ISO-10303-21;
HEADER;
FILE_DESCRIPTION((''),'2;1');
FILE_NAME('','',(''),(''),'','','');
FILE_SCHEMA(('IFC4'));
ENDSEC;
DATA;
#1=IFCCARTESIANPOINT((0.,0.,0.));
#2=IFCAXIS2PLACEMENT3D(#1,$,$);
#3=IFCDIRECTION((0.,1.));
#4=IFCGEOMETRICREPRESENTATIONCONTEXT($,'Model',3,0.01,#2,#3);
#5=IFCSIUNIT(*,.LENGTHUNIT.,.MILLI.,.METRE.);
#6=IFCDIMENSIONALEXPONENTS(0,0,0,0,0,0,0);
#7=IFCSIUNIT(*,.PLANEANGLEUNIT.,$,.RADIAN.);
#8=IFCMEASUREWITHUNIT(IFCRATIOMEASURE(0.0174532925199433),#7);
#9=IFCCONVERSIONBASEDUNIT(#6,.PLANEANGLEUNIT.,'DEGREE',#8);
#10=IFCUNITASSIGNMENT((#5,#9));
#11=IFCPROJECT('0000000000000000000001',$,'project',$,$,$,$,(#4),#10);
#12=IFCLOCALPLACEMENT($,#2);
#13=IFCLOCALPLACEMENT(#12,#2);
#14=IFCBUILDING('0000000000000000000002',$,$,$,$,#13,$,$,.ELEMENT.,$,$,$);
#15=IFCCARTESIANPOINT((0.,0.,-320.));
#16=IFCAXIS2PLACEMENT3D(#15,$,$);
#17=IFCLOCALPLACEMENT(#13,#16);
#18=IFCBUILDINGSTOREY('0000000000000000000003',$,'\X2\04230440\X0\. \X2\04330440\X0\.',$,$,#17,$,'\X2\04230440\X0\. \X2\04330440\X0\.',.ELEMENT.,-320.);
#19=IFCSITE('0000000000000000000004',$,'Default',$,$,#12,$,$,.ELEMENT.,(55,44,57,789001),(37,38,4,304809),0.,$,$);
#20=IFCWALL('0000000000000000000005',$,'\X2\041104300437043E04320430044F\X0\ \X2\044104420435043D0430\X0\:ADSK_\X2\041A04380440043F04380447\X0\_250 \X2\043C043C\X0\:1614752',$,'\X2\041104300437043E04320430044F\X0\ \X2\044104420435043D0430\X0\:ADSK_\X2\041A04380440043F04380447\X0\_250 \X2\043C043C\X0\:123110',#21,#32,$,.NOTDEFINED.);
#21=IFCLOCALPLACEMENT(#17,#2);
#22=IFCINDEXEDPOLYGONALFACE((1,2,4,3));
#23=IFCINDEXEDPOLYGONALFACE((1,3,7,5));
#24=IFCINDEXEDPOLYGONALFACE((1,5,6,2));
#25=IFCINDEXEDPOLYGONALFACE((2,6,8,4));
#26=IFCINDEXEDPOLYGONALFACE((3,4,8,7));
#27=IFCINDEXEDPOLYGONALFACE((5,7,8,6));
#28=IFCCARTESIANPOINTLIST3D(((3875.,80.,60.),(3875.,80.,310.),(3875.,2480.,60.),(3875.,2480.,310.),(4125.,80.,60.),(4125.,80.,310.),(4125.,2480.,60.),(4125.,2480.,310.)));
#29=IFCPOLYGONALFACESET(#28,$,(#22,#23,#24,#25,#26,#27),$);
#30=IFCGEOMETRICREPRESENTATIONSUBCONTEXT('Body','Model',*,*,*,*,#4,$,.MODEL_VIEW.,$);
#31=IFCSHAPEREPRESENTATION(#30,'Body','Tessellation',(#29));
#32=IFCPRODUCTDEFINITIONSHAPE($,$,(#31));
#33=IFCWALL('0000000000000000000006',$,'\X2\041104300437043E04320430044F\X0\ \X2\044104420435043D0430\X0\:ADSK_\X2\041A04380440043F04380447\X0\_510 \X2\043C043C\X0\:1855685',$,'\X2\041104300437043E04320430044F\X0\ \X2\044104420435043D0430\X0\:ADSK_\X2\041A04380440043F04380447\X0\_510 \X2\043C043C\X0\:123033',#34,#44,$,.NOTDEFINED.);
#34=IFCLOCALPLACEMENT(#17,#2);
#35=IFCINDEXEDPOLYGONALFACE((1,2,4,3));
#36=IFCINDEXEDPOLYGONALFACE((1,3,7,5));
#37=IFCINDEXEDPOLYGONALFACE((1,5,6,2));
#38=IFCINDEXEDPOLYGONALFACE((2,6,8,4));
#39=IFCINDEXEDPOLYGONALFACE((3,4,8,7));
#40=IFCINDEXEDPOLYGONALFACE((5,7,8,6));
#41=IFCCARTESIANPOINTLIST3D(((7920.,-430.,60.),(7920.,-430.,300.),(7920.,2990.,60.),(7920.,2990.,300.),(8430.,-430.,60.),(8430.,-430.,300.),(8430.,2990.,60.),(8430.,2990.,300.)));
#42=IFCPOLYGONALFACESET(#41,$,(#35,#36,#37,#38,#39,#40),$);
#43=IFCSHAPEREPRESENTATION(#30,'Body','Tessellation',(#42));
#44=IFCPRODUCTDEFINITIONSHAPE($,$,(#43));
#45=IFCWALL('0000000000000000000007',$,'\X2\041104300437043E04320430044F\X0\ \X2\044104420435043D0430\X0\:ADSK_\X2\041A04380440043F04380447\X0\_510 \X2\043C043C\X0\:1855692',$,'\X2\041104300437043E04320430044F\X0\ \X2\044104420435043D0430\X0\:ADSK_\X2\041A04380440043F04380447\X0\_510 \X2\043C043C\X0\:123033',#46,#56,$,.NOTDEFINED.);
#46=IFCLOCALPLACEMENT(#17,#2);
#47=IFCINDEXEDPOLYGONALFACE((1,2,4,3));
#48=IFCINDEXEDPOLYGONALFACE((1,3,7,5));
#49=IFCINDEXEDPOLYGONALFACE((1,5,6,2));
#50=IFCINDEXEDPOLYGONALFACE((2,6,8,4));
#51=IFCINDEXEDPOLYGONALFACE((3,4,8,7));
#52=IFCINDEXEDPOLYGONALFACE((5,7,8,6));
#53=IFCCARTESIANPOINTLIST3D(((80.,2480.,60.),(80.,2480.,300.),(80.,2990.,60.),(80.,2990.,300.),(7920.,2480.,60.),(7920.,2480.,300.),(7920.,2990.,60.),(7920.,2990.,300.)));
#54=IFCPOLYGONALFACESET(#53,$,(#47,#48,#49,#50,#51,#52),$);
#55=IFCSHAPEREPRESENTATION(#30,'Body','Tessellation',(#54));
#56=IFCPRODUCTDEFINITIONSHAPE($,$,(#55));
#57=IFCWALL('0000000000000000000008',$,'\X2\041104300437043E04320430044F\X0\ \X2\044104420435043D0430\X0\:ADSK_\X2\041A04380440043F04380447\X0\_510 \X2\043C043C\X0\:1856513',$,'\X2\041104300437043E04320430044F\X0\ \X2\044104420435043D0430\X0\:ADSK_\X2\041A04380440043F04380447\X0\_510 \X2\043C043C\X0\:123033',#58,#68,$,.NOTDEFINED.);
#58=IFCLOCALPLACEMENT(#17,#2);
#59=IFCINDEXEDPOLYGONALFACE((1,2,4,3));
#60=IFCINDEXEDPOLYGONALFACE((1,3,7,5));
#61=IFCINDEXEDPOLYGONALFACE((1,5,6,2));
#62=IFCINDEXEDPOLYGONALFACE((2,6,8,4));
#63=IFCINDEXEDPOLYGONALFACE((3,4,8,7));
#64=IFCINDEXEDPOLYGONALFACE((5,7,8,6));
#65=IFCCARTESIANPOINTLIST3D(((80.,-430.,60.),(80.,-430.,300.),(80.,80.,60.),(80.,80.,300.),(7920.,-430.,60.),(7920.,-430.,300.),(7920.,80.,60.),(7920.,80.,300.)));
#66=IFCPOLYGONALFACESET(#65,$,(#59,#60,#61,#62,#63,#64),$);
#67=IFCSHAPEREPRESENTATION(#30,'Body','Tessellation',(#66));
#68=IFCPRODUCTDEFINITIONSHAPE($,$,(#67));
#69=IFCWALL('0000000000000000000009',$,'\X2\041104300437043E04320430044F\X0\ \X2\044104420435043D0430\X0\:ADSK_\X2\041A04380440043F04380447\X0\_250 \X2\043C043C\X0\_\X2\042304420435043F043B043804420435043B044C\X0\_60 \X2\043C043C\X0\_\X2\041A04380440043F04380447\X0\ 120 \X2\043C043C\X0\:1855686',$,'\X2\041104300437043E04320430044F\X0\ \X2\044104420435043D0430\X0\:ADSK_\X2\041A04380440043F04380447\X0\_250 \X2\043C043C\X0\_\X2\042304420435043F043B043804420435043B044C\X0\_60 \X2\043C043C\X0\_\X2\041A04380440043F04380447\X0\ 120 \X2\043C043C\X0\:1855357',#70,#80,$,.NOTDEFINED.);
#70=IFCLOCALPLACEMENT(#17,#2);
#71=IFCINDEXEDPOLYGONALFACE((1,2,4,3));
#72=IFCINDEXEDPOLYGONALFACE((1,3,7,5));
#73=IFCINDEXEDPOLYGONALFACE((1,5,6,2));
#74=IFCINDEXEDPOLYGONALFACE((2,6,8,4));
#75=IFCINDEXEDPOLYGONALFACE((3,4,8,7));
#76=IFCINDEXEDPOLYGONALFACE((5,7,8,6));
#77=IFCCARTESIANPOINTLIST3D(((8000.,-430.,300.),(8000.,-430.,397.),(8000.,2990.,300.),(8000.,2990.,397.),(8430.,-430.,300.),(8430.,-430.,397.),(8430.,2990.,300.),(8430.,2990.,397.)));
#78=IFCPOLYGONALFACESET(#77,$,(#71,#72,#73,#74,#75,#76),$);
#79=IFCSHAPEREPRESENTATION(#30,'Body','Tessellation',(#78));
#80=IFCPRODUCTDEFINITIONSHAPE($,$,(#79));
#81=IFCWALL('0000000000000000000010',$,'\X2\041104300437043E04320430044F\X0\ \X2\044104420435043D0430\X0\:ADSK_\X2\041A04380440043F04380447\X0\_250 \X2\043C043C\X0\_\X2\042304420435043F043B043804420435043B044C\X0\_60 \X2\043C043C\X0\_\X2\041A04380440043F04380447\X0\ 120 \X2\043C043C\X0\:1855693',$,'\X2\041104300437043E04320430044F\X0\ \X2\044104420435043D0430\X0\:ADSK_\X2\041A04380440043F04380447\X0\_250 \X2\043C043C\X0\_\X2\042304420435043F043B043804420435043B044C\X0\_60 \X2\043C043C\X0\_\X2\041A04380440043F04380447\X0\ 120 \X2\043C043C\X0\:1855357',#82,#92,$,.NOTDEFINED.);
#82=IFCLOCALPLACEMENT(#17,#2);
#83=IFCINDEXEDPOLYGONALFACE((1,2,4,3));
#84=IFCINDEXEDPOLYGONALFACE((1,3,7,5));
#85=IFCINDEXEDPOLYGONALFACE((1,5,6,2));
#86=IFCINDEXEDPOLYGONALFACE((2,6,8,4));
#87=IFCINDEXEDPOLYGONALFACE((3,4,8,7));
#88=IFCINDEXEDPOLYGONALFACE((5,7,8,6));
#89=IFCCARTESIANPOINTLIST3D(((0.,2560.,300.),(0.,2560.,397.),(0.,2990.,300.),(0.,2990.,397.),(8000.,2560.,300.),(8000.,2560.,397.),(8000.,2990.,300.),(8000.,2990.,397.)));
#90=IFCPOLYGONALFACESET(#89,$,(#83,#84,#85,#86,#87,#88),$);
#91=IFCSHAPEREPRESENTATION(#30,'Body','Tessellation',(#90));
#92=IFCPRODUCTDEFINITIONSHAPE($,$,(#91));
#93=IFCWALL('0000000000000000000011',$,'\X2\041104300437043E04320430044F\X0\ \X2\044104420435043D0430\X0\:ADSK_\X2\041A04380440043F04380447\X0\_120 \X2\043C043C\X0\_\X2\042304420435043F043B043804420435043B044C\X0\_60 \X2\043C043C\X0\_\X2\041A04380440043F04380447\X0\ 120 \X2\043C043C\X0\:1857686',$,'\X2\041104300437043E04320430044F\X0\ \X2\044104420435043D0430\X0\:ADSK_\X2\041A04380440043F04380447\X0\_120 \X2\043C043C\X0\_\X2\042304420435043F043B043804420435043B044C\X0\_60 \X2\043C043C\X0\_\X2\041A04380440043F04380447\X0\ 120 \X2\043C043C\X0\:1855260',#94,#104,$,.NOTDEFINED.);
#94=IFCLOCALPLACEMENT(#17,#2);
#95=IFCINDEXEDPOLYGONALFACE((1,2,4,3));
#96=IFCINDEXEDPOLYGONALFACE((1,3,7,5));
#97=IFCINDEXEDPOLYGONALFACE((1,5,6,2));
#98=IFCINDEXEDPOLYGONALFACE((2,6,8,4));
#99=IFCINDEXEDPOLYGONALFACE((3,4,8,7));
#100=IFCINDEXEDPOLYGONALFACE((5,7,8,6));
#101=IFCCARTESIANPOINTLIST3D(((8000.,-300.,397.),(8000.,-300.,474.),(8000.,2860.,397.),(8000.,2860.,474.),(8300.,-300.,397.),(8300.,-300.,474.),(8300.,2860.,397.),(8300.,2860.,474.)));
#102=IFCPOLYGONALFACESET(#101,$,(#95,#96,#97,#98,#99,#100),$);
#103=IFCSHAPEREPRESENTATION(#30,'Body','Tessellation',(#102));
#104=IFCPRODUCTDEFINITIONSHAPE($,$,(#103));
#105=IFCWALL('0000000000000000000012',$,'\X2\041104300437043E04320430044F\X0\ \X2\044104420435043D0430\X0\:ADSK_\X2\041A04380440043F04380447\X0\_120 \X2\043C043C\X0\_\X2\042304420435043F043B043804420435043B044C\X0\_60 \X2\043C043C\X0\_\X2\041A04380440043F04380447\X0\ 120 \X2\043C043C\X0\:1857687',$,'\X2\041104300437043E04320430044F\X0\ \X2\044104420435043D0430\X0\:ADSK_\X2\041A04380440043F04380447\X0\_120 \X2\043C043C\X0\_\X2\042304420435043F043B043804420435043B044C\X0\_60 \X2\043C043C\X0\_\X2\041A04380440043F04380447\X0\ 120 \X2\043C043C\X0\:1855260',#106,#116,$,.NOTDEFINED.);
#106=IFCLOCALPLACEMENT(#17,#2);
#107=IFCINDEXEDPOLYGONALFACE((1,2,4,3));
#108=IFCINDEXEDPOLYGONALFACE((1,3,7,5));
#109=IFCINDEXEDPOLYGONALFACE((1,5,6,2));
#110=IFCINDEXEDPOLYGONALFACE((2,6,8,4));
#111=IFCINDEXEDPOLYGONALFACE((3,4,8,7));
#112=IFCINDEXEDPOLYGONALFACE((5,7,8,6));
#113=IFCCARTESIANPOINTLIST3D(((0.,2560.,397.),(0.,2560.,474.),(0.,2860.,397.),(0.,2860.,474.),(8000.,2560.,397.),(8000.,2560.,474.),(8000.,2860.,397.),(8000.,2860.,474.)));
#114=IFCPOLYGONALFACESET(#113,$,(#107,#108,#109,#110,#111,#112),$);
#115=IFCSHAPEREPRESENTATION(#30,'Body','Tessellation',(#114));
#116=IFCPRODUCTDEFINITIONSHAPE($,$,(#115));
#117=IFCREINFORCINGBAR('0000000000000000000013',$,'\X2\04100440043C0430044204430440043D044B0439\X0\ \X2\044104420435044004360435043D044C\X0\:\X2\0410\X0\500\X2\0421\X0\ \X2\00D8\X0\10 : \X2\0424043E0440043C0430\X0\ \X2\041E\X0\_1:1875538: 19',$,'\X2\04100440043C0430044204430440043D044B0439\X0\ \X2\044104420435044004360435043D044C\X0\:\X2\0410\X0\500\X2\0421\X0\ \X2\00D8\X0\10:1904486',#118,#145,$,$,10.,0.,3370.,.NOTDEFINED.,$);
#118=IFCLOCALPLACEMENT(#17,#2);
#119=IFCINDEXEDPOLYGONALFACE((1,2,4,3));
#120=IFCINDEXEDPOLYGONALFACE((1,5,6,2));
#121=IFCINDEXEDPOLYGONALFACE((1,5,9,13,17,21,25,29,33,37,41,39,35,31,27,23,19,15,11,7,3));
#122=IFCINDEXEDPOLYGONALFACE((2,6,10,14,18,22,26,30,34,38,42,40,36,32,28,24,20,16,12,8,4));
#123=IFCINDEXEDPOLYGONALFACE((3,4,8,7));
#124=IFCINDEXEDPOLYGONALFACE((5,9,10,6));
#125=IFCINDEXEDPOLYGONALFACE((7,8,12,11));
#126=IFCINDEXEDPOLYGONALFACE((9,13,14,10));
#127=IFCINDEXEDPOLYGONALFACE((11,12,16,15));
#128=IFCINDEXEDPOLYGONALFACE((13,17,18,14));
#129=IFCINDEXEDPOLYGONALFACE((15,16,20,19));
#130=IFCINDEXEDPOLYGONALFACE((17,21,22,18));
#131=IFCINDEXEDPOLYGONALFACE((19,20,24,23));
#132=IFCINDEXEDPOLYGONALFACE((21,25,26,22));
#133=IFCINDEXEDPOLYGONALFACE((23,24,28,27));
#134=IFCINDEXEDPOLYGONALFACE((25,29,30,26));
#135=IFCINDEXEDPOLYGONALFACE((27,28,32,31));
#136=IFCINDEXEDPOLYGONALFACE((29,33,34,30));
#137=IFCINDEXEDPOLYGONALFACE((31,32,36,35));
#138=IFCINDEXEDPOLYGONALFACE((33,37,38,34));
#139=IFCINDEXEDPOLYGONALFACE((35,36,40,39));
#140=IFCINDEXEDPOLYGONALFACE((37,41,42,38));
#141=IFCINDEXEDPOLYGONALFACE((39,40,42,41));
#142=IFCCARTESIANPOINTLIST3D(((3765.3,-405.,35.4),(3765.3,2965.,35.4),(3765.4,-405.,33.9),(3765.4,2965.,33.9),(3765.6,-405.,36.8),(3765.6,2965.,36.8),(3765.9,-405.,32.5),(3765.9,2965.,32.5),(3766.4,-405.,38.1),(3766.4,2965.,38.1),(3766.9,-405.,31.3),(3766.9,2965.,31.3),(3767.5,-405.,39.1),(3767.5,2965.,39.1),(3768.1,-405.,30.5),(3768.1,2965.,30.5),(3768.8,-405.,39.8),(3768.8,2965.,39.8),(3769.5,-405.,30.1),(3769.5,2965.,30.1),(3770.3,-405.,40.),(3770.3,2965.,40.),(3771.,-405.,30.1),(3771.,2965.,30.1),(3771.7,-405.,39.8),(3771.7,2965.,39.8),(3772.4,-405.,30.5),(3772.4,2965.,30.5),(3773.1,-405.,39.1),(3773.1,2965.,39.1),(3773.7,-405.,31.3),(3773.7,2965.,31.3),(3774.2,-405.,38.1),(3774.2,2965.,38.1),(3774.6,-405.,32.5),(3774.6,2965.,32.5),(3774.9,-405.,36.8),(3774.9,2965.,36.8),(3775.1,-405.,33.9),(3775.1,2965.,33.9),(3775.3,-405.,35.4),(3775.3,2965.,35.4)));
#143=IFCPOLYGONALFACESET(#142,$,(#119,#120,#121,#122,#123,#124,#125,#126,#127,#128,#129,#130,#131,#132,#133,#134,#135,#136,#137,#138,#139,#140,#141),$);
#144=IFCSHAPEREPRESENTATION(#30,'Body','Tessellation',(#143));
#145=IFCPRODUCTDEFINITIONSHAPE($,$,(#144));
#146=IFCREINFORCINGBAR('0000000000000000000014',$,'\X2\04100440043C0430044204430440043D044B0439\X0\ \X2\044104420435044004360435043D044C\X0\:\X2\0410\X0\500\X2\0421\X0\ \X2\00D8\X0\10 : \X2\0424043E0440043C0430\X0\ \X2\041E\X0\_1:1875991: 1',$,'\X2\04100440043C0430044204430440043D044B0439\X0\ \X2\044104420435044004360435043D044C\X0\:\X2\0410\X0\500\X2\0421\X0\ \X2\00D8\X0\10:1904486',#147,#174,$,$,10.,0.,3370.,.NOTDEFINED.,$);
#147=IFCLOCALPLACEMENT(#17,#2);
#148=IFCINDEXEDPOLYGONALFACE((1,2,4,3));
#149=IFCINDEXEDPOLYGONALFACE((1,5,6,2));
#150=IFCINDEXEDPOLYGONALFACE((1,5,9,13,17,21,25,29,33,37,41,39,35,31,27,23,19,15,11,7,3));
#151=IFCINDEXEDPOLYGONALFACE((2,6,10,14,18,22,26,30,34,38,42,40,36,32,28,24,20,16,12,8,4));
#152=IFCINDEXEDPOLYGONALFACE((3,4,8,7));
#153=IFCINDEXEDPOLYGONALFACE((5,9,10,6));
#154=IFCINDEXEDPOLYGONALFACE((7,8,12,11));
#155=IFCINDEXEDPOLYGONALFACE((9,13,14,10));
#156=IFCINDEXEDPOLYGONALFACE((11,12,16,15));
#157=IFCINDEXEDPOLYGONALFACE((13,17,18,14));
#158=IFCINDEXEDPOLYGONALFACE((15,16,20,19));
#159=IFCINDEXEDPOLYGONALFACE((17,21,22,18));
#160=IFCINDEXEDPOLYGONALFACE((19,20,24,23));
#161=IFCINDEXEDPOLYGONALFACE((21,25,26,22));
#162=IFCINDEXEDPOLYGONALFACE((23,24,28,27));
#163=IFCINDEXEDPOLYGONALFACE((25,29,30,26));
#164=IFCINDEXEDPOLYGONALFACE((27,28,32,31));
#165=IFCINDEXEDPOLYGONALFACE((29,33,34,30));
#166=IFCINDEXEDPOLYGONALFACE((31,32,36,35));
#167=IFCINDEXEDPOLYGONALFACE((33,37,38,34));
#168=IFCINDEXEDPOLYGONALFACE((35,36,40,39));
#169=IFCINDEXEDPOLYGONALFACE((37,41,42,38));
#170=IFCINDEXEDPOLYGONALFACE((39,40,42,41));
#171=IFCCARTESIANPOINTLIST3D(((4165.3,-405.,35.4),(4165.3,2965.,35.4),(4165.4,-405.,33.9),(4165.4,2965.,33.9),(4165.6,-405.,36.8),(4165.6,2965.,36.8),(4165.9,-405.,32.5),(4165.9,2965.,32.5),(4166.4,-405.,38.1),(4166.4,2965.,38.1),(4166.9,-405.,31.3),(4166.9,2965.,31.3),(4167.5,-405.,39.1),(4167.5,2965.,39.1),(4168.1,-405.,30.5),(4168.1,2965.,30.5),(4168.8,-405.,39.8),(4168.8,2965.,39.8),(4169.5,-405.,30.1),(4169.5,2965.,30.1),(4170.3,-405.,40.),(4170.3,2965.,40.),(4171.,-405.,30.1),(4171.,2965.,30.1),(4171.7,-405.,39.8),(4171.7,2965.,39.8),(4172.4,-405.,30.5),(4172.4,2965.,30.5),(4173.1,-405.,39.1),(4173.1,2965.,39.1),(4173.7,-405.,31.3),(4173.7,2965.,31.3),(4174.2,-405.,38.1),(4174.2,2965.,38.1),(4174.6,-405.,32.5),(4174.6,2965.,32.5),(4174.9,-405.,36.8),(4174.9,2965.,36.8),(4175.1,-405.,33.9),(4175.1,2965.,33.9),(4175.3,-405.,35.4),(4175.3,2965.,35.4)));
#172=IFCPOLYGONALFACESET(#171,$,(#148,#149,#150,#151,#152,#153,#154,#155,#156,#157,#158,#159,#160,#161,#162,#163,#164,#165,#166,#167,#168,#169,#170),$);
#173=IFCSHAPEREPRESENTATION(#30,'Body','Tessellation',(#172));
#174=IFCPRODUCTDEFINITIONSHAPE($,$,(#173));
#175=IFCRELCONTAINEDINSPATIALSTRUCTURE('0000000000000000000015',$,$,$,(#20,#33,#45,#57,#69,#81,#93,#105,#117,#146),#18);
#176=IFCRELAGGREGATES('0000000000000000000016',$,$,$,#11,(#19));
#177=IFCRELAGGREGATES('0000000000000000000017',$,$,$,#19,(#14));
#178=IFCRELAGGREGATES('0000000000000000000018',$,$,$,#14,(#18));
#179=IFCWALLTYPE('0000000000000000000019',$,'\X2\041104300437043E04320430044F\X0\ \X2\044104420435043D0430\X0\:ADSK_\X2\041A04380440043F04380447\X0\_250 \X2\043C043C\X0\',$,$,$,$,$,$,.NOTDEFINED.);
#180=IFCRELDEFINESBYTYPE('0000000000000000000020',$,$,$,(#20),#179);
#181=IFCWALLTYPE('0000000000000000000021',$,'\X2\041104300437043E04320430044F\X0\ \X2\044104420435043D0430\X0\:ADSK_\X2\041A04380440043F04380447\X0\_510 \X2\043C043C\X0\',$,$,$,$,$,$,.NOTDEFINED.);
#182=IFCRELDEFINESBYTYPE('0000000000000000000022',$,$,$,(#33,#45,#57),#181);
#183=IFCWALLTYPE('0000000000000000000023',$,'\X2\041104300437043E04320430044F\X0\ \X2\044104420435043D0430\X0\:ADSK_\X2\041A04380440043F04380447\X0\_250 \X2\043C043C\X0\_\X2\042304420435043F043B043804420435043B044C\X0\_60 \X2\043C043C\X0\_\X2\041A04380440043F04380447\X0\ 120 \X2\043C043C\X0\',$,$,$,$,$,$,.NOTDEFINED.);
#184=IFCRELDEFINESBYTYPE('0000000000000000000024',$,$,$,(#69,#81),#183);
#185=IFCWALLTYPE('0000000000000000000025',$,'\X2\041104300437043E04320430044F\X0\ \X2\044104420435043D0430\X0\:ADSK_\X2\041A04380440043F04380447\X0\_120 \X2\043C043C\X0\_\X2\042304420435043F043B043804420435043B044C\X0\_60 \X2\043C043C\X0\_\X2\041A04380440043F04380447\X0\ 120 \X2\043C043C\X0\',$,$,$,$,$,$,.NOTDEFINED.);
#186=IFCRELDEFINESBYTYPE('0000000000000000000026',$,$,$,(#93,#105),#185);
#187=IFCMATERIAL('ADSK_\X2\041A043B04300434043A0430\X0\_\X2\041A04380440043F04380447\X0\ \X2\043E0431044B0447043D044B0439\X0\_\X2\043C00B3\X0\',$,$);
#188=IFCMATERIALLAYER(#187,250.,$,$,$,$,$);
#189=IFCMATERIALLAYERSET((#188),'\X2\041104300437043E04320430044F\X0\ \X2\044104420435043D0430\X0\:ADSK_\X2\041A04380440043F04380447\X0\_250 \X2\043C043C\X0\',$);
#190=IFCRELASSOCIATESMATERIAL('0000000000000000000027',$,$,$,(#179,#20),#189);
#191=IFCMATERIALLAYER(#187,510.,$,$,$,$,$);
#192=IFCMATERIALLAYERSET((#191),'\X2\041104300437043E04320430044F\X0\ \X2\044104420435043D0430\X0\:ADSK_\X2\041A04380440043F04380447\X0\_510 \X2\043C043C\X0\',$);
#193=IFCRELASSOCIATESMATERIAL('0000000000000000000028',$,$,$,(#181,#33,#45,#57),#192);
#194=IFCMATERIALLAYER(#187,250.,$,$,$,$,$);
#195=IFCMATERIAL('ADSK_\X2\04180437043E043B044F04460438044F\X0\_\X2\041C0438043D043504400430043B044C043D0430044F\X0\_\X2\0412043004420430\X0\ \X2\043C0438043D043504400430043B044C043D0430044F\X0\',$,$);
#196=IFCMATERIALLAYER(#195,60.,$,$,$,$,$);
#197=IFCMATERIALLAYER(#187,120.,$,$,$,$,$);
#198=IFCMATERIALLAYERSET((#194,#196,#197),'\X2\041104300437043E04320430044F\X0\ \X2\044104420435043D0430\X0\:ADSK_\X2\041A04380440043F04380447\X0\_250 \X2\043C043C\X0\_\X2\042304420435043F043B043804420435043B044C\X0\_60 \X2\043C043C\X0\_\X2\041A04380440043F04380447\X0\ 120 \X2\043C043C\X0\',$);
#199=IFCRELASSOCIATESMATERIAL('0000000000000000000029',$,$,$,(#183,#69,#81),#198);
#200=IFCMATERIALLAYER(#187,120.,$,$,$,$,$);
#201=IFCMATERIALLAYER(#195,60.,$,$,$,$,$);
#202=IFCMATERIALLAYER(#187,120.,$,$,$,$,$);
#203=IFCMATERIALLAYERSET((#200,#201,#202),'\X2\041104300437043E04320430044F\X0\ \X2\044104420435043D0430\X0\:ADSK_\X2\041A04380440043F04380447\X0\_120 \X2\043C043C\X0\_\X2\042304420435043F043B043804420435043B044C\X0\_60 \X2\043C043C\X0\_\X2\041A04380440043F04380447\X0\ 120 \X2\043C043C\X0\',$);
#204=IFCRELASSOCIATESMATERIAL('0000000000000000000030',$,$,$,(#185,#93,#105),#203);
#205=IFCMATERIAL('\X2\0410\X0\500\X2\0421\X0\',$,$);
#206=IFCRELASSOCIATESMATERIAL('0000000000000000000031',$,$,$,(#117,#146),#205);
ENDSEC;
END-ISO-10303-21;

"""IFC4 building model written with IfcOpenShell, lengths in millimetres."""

from ifc_helpers import new_model, entity, si_unit, converted_unit, direction, frame, frame_2d, origin, place, context, subcontext, project, spatial, polyline, rectangle, extrude, clip, bounded_halfspace, material, layer, layer_set, layer_usage, type_object, element, save


model = new_model("IFC4")

# Units and contexts
model_context = context("Model", 3, precision=0.01, world=origin(), true_north=direction((0.0, 1.0)))
body_context = subcontext(model_context, "Body", "Model", "MODEL_VIEW")
ifc_project = project(units=[si_unit("LENGTHUNIT", "METRE", prefix="MILLI"), converted_unit("PLANEANGLEUNIT", "DEGREE", entity("IfcRatioMeasure", 0.0174532925199433), si_unit("PLANEANGLEUNIT", "RADIAN"), dimensions=[0, 0, 0, 0, 0, 0, 0])], contexts=[model_context])

# Site, building, storey
site_placement = place(None, origin())
site = spatial("IfcSite", under=ifc_project, at=site_placement, Name="Default", CompositionType="ELEMENT", RefLatitude=(55, 44, 57, 789001), RefLongitude=(37, 38, 4, 304809), RefElevation=0.0)
building_placement = place(site_placement, origin())
building = spatial("IfcBuilding", under=site, at=building_placement, CompositionType="ELEMENT")
storey_placement = place(building_placement, frame((0.0, 0.0, -320.0)))
storey = spatial("IfcBuildingStorey", under=building, at=storey_placement, Name="Ур. гр.", LongName="Ур. гр.", CompositionType="ELEMENT", Elevation=-320.0)

# Walls
ifc_material_1 = material(Name="ADSK_Кладка_Кирпич обычный_м³")
ifc_layer_1 = layer(ifc_material_1, 250.0)
ifc_layer_set_1 = layer_set([ifc_layer_1], Name="Базовая стена:ADSK_Кирпич_250 мм")
ifc_layer_usage_1 = layer_usage(ifc_layer_set_1, "AXIS2", "POSITIVE", -125.0)
wall_type_1 = type_object("IfcWallType", Name="Базовая стена:ADSK_Кирпич_250 мм", PredefinedType="NOTDEFINED", material=ifc_layer_set_1)
wall_1_placement = place(storey_placement, frame((4000.0, 2560.0, 60.0), z_axis=(0.0, 0.0, 1.0), x_axis=(0.0, -1.0, 0.0)))
element("IfcWall", 1, at=wall_1_placement, inside=storey, type_object=wall_type_1, material=ifc_layer_usage_1, Name="Базовая стена:ADSK_Кирпич_250 мм:1614752", ObjectType="Базовая стена:ADSK_Кирпич_250 мм:123110", PredefinedType="NOTDEFINED", context=body_context, shape_type="SweptSolid", body=[
    extrude(rectangle(XDim=2400.0, YDim=250.0, at=frame_2d((1280.0, 0.0), x_axis=(-1.0, 0.0))), origin(), (0.0, 0.0, 1.0), 250.0),
])
ifc_layer_2 = layer(ifc_material_1, 510.0)
ifc_layer_set_2 = layer_set([ifc_layer_2], Name="Базовая стена:ADSK_Кирпич_510 мм")
ifc_layer_usage_2 = layer_usage(ifc_layer_set_2, "AXIS2", "POSITIVE", -255.0)
wall_type_2 = type_object("IfcWallType", Name="Базовая стена:ADSK_Кирпич_510 мм", PredefinedType="NOTDEFINED", material=ifc_layer_set_2)
wall_2_placement = place(storey_placement, frame((8175.0, -430.0, 60.0), z_axis=(0.0, 0.0, 1.0), x_axis=(0.0, 1.0, 0.0)))
element("IfcWall", 2, at=wall_2_placement, inside=storey, type_object=wall_type_2, material=ifc_layer_usage_2, Name="Базовая стена:ADSK_Кирпич_510 мм:1855685", ObjectType="Базовая стена:ADSK_Кирпич_510 мм:123033", PredefinedType="NOTDEFINED", context=body_context, shape_type="SweptSolid", body=[
    extrude(rectangle(XDim=3420.0, YDim=510.0, at=frame_2d((1710.0, 0.0), x_axis=(-1.0, 0.0))), origin(), (0.0, 0.0, 1.0), 240.0),
])
ifc_layer_usage_3 = layer_usage(ifc_layer_set_2, "AXIS2", "POSITIVE", -255.0)
wall_3_placement = place(storey_placement, frame((7920.0, 2735.0, 60.0), z_axis=(0.0, 0.0, 1.0), x_axis=(-1.0, 0.0, 0.0)))
element("IfcWall", 3, at=wall_3_placement, inside=storey, type_object=wall_type_2, material=ifc_layer_usage_3, Name="Базовая стена:ADSK_Кирпич_510 мм:1855692", ObjectType="Базовая стена:ADSK_Кирпич_510 мм:123033", PredefinedType="NOTDEFINED", context=body_context, shape_type="SweptSolid", body=[
    extrude(rectangle(XDim=7840.0, YDim=510.0, at=frame_2d((3920.0, 0.0), x_axis=(-1.0, 0.0))), origin(), (0.0, 0.0, 1.0), 240.0),
])
ifc_layer_usage_4 = layer_usage(ifc_layer_set_2, "AXIS2", "POSITIVE", -255.0)
wall_4_placement = place(storey_placement, frame((80.0, -175.0, 60.0)))
element("IfcWall", 4, at=wall_4_placement, inside=storey, type_object=wall_type_2, material=ifc_layer_usage_4, Name="Базовая стена:ADSK_Кирпич_510 мм:1856513", ObjectType="Базовая стена:ADSK_Кирпич_510 мм:123033", PredefinedType="NOTDEFINED", context=body_context, shape_type="Clipping", body=[
    clip(extrude(rectangle(XDim=7840.0, YDim=510.0, at=frame_2d((3920.0, 0.0), x_axis=(-1.0, 0.0))), origin(), (0.0, 0.0, 1.0), 240.0), bounded_halfspace(frame((0.0, -255.0, 240.0), z_axis=(0.0, 0.0, -1.0), x_axis=(0.0, 1.0, 0.0)), True, frame((0.0, -255.0, 240.0)), polyline([(0.0, 0.0), (7840.0, 0.0), (7840.0, 510.0), (0.0, 510.0), (0.0, 0.0)]))),
])
ifc_layer_3 = layer(ifc_material_1, 250.0)
ifc_material_2 = material(Name="ADSK_Изоляция_Минеральная_Вата минеральная")
ifc_layer_4 = layer(ifc_material_2, 60.0)
ifc_layer_5 = layer(ifc_material_1, 120.0)
ifc_layer_set_3 = layer_set([ifc_layer_3, ifc_layer_4, ifc_layer_5], Name="Базовая стена:ADSK_Кирпич_250 мм_Утеплитель_60 мм_Кирпич 120 мм")
ifc_layer_usage_5 = layer_usage(ifc_layer_set_3, "AXIS2", "POSITIVE", -215.0)
wall_type_3 = type_object("IfcWallType", Name="Базовая стена:ADSK_Кирпич_250 мм_Утеплитель_60 мм_Кирпич 120 мм", PredefinedType="NOTDEFINED", material=ifc_layer_set_3)
wall_5_placement = place(storey_placement, frame((8215.0, -430.0, 300.0), z_axis=(0.0, 0.0, 1.0), x_axis=(0.0, 1.0, 0.0)))
element("IfcWall", 5, at=wall_5_placement, inside=storey, type_object=wall_type_3, material=ifc_layer_usage_5, Name="Базовая стена:ADSK_Кирпич_250 мм_Утеплитель_60 мм_Кирпич 120 мм:1855686", ObjectType="Базовая стена:ADSK_Кирпич_250 мм_Утеплитель_60 мм_Кирпич 120 мм:1855357", PredefinedType="NOTDEFINED", context=body_context, shape_type="Clipping", body=[
    clip(extrude(rectangle(XDim=3420.0, YDim=430.0, at=frame_2d((1710.0, 0.0), x_axis=(-1.0, 0.0))), origin(), (0.0, 0.0, 1.0), 97.0), bounded_halfspace(frame((0.0, -215.0, 97.0), z_axis=(0.0, 0.0, -1.0), x_axis=(0.0, 1.0, 0.0)), True, frame((0.0, -215.0, 97.0)), polyline([(0.0, 0.0), (3420.0, 0.0), (3420.0, 430.0), (3290.0, 430.0), (2990.0, 430.0), (430.0, 430.0), (130.0, 430.0), (0.0, 430.0), (0.0, 0.0)]))),
])
ifc_layer_usage_6 = layer_usage(ifc_layer_set_3, "AXIS2", "POSITIVE", -215.0)
wall_6_placement = place(storey_placement, frame((8000.0, 2775.0, 300.0), z_axis=(0.0, 0.0, 1.0), x_axis=(-1.0, 0.0, 0.0)))
element("IfcWall", 6, at=wall_6_placement, inside=storey, type_object=wall_type_3, material=ifc_layer_usage_6, Name="Базовая стена:ADSK_Кирпич_250 мм_Утеплитель_60 мм_Кирпич 120 мм:1855693", ObjectType="Базовая стена:ADSK_Кирпич_250 мм_Утеплитель_60 мм_Кирпич 120 мм:1855357", PredefinedType="NOTDEFINED", context=body_context, shape_type="Clipping", body=[
    clip(extrude(rectangle(XDim=8000.0, YDim=430.0, at=frame_2d((4000.0, 0.0), x_axis=(-1.0, 0.0))), origin(), (0.0, 0.0, 1.0), 97.0), bounded_halfspace(frame((0.0, -215.0, 97.0), z_axis=(0.0, 0.0, -1.0), x_axis=(0.0, 1.0, 0.0)), True, frame((0.0, -215.0, 97.0)), polyline([(0.0, 0.0), (8000.0, 0.0), (8000.0, 130.0), (8000.0, 430.0), (0.0, 430.0), (0.0, 130.0), (0.0, 0.0)]))),
])
ifc_layer_6 = layer(ifc_material_1, 120.0)
ifc_layer_7 = layer(ifc_material_2, 60.0)
ifc_layer_8 = layer(ifc_material_1, 120.0)
ifc_layer_set_4 = layer_set([ifc_layer_6, ifc_layer_7, ifc_layer_8], Name="Базовая стена:ADSK_Кирпич_120 мм_Утеплитель_60 мм_Кирпич 120 мм")
ifc_layer_usage_7 = layer_usage(ifc_layer_set_4, "AXIS2", "POSITIVE", -150.0)
wall_type_4 = type_object("IfcWallType", Name="Базовая стена:ADSK_Кирпич_120 мм_Утеплитель_60 мм_Кирпич 120 мм", PredefinedType="NOTDEFINED", material=ifc_layer_set_4)
wall_7_placement = place(storey_placement, frame((8150.0, -300.0, 397.0), z_axis=(0.0, 0.0, 1.0), x_axis=(0.0, 1.0, 0.0)))
element("IfcWall", 7, at=wall_7_placement, inside=storey, type_object=wall_type_4, material=ifc_layer_usage_7, Name="Базовая стена:ADSK_Кирпич_120 мм_Утеплитель_60 мм_Кирпич 120 мм:1857686", ObjectType="Базовая стена:ADSK_Кирпич_120 мм_Утеплитель_60 мм_Кирпич 120 мм:1855260", PredefinedType="NOTDEFINED", context=body_context, shape_type="SweptSolid", body=[
    extrude(rectangle(XDim=3160.0, YDim=300.0, at=frame_2d((1580.0, 0.0), x_axis=(-1.0, 0.0))), origin(), (0.0, 0.0, 1.0), 77.0),
])
ifc_layer_usage_8 = layer_usage(ifc_layer_set_4, "AXIS2", "POSITIVE", -150.0)
wall_8_placement = place(storey_placement, frame((8000.0, 2710.0, 397.0), z_axis=(0.0, 0.0, 1.0), x_axis=(-1.0, 0.0, 0.0)))
element("IfcWall", 8, at=wall_8_placement, inside=storey, type_object=wall_type_4, material=ifc_layer_usage_8, Name="Базовая стена:ADSK_Кирпич_120 мм_Утеплитель_60 мм_Кирпич 120 мм:1857687", ObjectType="Базовая стена:ADSK_Кирпич_120 мм_Утеплитель_60 мм_Кирпич 120 мм:1855260", PredefinedType="NOTDEFINED", context=body_context, shape_type="SweptSolid", body=[
    extrude(rectangle(XDim=8000.0, YDim=300.0, at=frame_2d((4000.0, 0.0), x_axis=(-1.0, 0.0))), origin(), (0.0, 0.0, 1.0), 77.0),
])

# Reinforcing bars
ifc_material_3 = material(Name="А500С")
reinforcing_bar_1_placement = place(storey_placement, origin())
element("IfcReinforcingBar", 9, at=reinforcing_bar_1_placement, inside=storey, material=ifc_material_3, Name="Арматурный стержень:А500С Ø10 : Форма О_1:1875538: 19", ObjectType="Арматурный стержень:А500С Ø10:1904486", BarLength=3370.0, CrossSectionArea=0.0, NominalDiameter=10.0, PredefinedType="NOTDEFINED", context=body_context, shape_type="AdvancedSweptSolid", body=[
    entity("IfcSweptDiskSolid", entity("IfcCompositeCurve", [entity("IfcCompositeCurveSegment", "CONTINUOUS", True, entity("IfcPolyline", [entity("IfcCartesianPoint", [3770.3, -405.0, 35.0]), entity("IfcCartesianPoint", [3770.3, 2965.0, 35.0])]))], False), 5.0, None, 0.0, 1.0),
])
reinforcing_bar_2_placement = place(storey_placement, origin())
element("IfcReinforcingBar", 10, at=reinforcing_bar_2_placement, inside=storey, material=ifc_material_3, Name="Арматурный стержень:А500С Ø10 : Форма О_1:1875991: 1", ObjectType="Арматурный стержень:А500С Ø10:1904486", BarLength=3370.0, CrossSectionArea=0.0, NominalDiameter=10.0, PredefinedType="NOTDEFINED", context=body_context, shape_type="AdvancedSweptSolid", body=[
    entity("IfcSweptDiskSolid", entity("IfcCompositeCurve", [entity("IfcCompositeCurveSegment", "CONTINUOUS", True, entity("IfcPolyline", [entity("IfcCartesianPoint", [4170.3, -405.0, 35.0]), entity("IfcCartesianPoint", [4170.3, 2965.0, 35.0])]))], False), 5.0, None, 0.0, 1.0),
])

save(model, "model.ifc")
